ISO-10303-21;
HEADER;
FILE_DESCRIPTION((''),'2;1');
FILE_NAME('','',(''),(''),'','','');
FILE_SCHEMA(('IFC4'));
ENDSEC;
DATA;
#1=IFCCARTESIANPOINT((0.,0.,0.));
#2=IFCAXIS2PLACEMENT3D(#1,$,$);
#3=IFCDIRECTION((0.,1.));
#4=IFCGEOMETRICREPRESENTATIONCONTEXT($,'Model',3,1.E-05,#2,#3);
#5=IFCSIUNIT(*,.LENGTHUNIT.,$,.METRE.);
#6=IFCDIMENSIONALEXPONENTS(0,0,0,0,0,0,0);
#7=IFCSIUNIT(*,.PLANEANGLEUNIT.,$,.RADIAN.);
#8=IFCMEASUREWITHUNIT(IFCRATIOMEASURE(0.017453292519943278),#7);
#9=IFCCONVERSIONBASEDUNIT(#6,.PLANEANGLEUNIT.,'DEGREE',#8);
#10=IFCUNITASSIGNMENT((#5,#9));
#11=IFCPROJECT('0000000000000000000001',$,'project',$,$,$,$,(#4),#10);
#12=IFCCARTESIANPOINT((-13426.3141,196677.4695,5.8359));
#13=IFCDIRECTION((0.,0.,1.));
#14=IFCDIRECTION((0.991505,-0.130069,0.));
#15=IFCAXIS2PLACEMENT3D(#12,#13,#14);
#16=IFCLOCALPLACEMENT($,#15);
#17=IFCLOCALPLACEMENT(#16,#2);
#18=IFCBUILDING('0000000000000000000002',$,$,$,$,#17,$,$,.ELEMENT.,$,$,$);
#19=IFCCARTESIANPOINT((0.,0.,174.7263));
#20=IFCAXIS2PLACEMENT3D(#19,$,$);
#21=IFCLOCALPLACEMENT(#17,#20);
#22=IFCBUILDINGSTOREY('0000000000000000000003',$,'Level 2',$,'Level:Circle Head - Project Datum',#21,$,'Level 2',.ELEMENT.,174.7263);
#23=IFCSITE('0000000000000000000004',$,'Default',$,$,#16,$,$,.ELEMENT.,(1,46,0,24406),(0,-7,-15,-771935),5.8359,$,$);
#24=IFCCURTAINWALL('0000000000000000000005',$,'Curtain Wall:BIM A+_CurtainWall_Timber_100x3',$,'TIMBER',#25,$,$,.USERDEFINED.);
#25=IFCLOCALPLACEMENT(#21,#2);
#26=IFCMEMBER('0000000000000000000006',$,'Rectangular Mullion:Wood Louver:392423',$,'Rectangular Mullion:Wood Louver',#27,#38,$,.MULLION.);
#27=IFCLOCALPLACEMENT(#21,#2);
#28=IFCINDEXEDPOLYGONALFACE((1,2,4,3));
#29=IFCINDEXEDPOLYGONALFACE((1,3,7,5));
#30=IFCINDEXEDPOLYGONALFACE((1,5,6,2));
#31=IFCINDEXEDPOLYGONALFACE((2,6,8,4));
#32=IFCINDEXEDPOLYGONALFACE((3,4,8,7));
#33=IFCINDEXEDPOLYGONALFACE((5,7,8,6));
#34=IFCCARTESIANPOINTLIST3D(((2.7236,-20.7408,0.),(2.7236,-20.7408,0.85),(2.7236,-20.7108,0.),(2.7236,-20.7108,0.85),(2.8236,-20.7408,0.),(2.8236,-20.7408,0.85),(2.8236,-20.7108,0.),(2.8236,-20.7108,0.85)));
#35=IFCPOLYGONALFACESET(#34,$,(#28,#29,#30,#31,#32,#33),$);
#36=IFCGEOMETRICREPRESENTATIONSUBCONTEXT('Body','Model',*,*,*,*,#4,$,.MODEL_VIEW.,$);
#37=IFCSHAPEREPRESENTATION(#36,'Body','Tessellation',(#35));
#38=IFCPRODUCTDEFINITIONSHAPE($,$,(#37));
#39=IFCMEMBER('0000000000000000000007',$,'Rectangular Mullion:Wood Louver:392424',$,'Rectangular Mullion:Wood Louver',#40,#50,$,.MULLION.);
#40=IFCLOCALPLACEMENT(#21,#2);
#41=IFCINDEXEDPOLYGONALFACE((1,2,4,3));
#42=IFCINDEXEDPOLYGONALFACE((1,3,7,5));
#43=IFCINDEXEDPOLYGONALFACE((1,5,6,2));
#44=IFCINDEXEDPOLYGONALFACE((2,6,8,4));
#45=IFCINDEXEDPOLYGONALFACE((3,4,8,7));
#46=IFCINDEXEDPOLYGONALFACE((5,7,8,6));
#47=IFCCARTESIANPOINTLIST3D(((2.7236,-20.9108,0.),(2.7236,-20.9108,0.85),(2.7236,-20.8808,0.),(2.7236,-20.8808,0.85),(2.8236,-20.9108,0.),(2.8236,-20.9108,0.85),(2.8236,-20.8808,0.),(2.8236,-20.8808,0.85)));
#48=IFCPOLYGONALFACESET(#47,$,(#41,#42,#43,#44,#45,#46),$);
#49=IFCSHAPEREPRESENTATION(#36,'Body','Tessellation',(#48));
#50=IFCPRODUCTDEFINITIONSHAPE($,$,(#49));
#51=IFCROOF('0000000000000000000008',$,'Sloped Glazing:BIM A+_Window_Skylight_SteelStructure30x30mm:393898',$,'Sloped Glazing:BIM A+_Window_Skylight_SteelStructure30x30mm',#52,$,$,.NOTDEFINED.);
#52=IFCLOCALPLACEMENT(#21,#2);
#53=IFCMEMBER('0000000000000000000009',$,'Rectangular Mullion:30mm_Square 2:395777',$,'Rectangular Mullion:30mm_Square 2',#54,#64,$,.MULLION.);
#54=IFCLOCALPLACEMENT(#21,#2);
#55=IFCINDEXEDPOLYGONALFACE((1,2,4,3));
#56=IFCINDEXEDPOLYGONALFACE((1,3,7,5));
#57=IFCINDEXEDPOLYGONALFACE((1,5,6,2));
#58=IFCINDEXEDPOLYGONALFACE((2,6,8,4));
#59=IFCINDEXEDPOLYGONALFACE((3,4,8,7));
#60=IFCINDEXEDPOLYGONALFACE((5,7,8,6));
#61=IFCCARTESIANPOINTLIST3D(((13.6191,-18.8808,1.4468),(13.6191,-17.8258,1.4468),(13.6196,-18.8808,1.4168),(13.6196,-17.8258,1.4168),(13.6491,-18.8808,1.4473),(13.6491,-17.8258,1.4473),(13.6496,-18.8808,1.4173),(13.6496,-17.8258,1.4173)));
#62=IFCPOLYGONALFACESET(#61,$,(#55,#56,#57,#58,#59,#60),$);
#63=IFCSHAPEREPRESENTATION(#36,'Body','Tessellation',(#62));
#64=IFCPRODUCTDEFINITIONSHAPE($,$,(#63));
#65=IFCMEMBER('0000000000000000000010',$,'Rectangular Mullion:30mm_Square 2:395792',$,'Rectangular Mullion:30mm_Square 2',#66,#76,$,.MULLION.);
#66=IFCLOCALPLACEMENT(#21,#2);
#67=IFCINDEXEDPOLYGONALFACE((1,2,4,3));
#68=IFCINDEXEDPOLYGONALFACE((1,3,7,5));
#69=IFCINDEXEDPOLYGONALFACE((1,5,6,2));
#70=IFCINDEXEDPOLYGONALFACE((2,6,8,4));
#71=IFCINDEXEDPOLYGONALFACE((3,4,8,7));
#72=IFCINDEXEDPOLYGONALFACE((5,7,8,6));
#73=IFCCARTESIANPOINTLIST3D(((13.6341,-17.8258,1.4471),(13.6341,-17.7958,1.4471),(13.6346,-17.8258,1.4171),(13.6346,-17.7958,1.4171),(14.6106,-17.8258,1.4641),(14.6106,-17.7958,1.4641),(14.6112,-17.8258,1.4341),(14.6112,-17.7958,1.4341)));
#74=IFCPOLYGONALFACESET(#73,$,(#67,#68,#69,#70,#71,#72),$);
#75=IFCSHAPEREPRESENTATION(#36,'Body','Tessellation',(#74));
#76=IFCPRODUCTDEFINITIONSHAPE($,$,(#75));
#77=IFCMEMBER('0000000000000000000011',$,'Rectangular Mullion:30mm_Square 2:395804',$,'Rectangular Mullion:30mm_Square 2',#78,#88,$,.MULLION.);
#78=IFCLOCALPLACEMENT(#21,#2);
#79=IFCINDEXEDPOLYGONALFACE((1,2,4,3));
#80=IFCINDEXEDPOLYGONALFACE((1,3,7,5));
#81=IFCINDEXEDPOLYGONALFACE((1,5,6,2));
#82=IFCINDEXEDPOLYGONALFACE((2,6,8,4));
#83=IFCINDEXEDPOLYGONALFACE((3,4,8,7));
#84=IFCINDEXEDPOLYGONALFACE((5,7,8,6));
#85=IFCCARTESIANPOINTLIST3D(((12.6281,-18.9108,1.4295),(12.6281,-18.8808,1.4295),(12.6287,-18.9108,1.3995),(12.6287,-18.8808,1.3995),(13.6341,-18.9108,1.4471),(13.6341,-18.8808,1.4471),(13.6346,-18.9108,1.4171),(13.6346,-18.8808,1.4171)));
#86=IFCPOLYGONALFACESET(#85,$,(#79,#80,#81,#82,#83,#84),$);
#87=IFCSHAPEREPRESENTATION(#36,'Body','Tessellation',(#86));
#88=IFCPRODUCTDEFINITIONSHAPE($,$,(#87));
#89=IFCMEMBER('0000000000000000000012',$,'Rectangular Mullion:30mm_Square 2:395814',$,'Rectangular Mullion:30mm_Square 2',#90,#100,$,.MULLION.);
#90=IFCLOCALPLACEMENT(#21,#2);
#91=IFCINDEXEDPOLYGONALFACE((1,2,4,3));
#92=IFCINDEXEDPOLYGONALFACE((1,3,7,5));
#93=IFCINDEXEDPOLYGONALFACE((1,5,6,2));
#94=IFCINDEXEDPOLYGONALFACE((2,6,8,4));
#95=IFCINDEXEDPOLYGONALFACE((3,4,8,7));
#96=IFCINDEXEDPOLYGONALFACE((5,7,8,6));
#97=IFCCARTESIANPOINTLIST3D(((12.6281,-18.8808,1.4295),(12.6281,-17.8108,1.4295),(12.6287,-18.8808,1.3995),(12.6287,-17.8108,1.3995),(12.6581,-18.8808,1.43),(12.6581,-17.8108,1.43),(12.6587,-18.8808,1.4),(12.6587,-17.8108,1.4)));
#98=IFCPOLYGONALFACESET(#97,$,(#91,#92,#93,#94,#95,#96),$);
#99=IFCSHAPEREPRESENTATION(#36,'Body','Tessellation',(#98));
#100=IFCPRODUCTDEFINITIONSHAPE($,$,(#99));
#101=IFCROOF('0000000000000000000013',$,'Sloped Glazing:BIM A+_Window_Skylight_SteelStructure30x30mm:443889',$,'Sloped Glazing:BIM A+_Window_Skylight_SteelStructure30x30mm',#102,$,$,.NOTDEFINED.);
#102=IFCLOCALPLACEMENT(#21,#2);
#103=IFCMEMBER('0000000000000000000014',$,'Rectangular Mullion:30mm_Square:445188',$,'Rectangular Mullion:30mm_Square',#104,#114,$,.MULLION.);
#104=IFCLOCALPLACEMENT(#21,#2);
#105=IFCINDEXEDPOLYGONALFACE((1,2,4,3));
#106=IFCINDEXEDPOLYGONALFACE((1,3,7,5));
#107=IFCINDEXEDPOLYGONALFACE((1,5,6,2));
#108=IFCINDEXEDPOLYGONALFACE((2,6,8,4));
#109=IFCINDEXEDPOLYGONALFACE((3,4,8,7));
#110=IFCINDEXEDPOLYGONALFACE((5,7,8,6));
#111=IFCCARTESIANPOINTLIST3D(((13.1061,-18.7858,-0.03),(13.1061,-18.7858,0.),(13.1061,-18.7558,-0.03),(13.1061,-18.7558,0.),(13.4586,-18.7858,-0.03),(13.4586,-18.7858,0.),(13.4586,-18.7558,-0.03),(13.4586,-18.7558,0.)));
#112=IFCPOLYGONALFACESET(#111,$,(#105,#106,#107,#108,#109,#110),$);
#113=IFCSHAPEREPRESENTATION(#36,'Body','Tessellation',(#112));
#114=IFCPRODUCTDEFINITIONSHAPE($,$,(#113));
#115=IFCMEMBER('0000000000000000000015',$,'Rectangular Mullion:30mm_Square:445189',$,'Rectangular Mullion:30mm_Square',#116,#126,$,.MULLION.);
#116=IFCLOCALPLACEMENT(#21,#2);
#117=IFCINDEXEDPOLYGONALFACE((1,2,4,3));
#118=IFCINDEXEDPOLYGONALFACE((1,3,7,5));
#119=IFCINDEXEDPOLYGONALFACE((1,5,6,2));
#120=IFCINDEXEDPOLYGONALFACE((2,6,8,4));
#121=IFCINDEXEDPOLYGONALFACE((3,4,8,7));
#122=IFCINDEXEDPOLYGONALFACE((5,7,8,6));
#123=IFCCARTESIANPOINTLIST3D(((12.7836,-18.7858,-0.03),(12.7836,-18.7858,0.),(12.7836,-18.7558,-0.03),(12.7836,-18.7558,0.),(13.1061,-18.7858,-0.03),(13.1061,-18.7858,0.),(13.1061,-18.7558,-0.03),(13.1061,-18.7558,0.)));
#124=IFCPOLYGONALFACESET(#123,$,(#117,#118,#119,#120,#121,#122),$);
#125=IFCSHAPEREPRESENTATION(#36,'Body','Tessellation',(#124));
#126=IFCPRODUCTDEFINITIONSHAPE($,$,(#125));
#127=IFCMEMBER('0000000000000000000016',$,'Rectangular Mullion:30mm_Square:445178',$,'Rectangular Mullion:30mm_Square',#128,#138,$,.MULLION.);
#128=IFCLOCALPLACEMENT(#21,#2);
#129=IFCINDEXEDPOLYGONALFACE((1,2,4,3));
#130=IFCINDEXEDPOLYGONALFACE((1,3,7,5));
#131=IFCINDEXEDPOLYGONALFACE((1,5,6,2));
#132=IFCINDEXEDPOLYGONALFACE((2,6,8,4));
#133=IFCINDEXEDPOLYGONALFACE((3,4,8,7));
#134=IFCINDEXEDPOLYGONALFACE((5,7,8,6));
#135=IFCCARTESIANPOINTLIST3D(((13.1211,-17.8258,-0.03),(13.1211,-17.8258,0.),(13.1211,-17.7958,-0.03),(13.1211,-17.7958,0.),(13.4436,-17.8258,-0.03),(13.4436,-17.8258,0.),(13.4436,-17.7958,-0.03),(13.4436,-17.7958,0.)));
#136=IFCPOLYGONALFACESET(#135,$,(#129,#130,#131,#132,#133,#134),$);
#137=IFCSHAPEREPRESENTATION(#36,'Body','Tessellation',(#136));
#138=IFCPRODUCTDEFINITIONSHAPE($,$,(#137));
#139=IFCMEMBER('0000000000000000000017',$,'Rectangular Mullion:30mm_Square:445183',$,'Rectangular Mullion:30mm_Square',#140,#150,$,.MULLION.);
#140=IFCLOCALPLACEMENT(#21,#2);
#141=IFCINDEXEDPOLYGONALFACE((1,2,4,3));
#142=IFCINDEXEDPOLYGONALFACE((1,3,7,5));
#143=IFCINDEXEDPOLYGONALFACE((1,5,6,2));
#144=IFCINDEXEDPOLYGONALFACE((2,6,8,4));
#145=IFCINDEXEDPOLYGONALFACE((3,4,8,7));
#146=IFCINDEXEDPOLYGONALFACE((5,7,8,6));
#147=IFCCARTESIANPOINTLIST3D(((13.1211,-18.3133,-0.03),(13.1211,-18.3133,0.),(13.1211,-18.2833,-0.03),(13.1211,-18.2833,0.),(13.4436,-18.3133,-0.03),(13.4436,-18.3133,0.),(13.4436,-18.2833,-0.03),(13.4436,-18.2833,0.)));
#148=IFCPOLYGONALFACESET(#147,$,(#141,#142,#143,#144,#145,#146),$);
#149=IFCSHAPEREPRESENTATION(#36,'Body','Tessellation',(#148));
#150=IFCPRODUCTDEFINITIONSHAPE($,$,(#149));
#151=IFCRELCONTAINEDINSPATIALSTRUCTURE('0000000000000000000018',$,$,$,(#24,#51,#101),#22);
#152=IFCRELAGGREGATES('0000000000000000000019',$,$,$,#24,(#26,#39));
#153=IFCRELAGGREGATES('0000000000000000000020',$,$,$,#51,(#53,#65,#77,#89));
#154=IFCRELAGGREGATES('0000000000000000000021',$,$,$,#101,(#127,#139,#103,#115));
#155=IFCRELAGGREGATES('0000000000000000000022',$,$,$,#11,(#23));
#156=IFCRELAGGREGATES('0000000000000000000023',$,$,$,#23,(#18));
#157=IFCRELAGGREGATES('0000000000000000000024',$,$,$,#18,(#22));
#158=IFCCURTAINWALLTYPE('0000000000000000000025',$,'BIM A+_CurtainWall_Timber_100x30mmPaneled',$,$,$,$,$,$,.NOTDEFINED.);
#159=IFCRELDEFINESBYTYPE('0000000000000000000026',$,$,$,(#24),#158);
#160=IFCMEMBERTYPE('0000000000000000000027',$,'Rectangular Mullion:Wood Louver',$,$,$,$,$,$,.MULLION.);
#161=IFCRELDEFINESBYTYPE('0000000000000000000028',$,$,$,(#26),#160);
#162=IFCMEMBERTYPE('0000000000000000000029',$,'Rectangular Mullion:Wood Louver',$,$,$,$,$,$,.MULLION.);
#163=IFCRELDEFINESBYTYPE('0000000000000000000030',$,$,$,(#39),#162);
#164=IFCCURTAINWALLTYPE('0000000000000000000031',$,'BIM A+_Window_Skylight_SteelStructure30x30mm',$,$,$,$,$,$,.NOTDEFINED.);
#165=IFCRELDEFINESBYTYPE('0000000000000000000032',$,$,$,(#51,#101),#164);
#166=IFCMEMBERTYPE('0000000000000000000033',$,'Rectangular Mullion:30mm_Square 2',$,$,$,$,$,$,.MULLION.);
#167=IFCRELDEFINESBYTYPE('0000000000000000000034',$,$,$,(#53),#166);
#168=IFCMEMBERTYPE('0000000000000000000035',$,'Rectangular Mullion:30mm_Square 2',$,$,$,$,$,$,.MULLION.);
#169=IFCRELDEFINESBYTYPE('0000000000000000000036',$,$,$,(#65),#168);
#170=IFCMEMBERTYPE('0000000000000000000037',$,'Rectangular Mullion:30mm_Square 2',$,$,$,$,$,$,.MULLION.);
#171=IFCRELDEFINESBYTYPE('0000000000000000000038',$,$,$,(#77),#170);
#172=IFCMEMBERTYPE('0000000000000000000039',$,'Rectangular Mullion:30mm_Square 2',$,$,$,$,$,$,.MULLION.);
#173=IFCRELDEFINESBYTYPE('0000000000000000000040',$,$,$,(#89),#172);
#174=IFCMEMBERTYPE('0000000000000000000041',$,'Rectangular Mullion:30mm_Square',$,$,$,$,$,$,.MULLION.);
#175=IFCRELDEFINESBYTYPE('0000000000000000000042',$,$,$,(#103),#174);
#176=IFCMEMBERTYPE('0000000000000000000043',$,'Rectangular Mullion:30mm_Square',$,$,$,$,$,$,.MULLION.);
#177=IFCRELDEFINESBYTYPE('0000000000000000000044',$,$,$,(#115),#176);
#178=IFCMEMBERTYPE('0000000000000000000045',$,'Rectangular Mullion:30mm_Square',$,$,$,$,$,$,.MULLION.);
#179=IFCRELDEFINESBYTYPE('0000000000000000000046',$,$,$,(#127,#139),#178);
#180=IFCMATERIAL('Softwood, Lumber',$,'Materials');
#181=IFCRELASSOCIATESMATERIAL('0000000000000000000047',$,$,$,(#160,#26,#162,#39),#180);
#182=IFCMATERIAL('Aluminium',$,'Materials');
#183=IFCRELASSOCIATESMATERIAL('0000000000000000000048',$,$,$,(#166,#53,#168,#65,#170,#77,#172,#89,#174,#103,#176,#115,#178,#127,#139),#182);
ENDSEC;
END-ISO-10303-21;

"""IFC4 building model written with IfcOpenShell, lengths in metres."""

from ifc_helpers import new_model, entity, si_unit, converted_unit, direction, frame, origin, place, context, subcontext, project, spatial, indexed_curve, outline, extrude, source, transform, mapped, material, type_object, type_shapes, element, aggregate, save


model = new_model("IFC4")

# Units and contexts
model_context = context("Model", 3, precision=1e-05, world=origin(), true_north=direction((0.0, 1.0)))
body_context = subcontext(model_context, "Body", "Model", "MODEL_VIEW")
ifc_project = project(units=[si_unit("LENGTHUNIT", "METRE"), converted_unit("PLANEANGLEUNIT", "DEGREE", entity("IfcRatioMeasure", 0.017453292519943278), si_unit("PLANEANGLEUNIT", "RADIAN"), dimensions=[0, 0, 0, 0, 0, 0, 0])], contexts=[model_context])

# Site, building, storey
site_placement = place(None, frame((-13426.3141, 196677.4695, 5.8359), z_axis=(0.0, 0.0, 1.0), x_axis=(0.991505, -0.130069, 0.0)))
site = spatial("IfcSite", under=ifc_project, at=site_placement, Name="Default", CompositionType="ELEMENT", RefLatitude=(1, 46, 0, 24406), RefLongitude=(0, -7, -15, -771935), RefElevation=5.8359)
building_placement = place(site_placement, origin())
building = spatial("IfcBuilding", under=site, at=building_placement, CompositionType="ELEMENT")
storey_placement = place(building_placement, frame((0.0, 0.0, 174.7263)))
storey = spatial("IfcBuildingStorey", under=building, at=storey_placement, Name="Level 2", ObjectType="Level:Circle Head - Project Datum", LongName="Level 2", CompositionType="ELEMENT", Elevation=174.7263)

# Curtain wall, members
curtain_wall_type_1 = type_object("IfcCurtainWallType", Name="BIM A+_CurtainWall_Timber_100x30mmPaneled", PredefinedType="NOTDEFINED")
curtain_wall_placement = place(storey_placement, frame((0.0, 0.0, -174.7263)))
curtain_wall = element("IfcCurtainWall", 1, at=curtain_wall_placement, inside=storey, type_object=curtain_wall_type_1, Name="Curtain Wall:BIM A+_CurtainWall_Timber_100x3", ObjectType="TIMBER", PredefinedType="USERDEFINED")
ifc_material_1 = material(Name="Softwood, Lumber", Category="Materials")
member_type_1 = type_object("IfcMemberType", Name="Rectangular Mullion:Wood Louver", PredefinedType="MULLION", material=ifc_material_1)
shared_shape_1 = source(origin(), body_context, "Body", "SweptSolid", [
    extrude(outline(indexed_curve([(-0.05, -0.015), (0.05, -0.015), (0.05, 0.015), (-0.05, 0.015), (-0.05, -0.015)], self_intersect=False)), frame((-0.015, -0.035, -0.85), z_axis=(0.0, 0.0, 1.0), x_axis=(0.0, -1.0, 0.0)), (0.0, 0.0, 1.0), 0.85),
])
type_shapes(member_type_1, [shared_shape_1])
member_1_placement = place(curtain_wall_placement, frame((2.8086, -20.7108, 174.7263), z_axis=(0.0, 0.0, -1.0), x_axis=(0.0, 1.0, 0.0)))
member_1 = element("IfcMember", 2, at=member_1_placement, type_object=member_type_1, material=ifc_material_1, Name="Rectangular Mullion:Wood Louver:392423", ObjectType="Rectangular Mullion:Wood Louver", PredefinedType="MULLION", context=body_context, shape_type="MappedRepresentation", body=[
    mapped(shared_shape_1, transform((0.0, 0.0, 0.0), scale=1.0)),
])
member_type_2 = type_object("IfcMemberType", Name="Rectangular Mullion:Wood Louver", PredefinedType="MULLION", material=ifc_material_1)
shared_shape_2 = source(origin(), body_context, "Body", "SweptSolid", [
    extrude(outline(indexed_curve([(-0.05, -0.015), (0.05, -0.015), (0.05, 0.015), (-0.05, 0.015), (-0.05, -0.015)], self_intersect=False)), frame((-0.015, -0.035, -0.85), z_axis=(0.0, 0.0, 1.0), x_axis=(0.0, -1.0, 0.0)), (0.0, 0.0, 1.0), 0.85),
])
type_shapes(member_type_2, [shared_shape_2])
member_2_placement = place(curtain_wall_placement, frame((2.8086, -20.9108, 175.5763), z_axis=(0.0, 0.0, 1.0), x_axis=(0.0, -1.0, 0.0)))
member_2 = element("IfcMember", 3, at=member_2_placement, type_object=member_type_2, material=ifc_material_1, Name="Rectangular Mullion:Wood Louver:392424", ObjectType="Rectangular Mullion:Wood Louver", PredefinedType="MULLION", context=body_context, shape_type="MappedRepresentation", body=[
    mapped(shared_shape_2, transform((0.0, 0.0, 0.0), scale=1.0)),
])

# Roofs, members
curtain_wall_type_2 = type_object("IfcCurtainWallType", Name="BIM A+_Window_Skylight_SteelStructure30x30mm", PredefinedType="NOTDEFINED")
roof_1_placement = place(storey_placement, frame((0.0, 0.0, -174.7263)))
roof_1 = element("IfcRoof", 4, at=roof_1_placement, inside=storey, type_object=curtain_wall_type_2, Name="Sloped Glazing:BIM A+_Window_Skylight_SteelStructure30x30mm:393898", ObjectType="Sloped Glazing:BIM A+_Window_Skylight_SteelStructure30x30mm", PredefinedType="NOTDEFINED")
ifc_material_2 = material(Name="Aluminium", Category="Materials")
member_type_3 = type_object("IfcMemberType", Name="Rectangular Mullion:30mm_Square 2", PredefinedType="MULLION", material=ifc_material_2)
shared_shape_3 = source(origin(), body_context, "Body", "SweptSolid", [
    extrude(outline(indexed_curve([(-0.015, -0.015), (0.015, -0.015), (0.015, 0.015), (-0.015, 0.015), (-0.015, -0.015)], self_intersect=False)), frame((0.0, -0.0095, -1.055), z_axis=(0.0, 0.0, 1.0), x_axis=(0.0, -1.0, 0.0)), (0.0, 0.0, 1.0), 1.055),
])
type_shapes(member_type_3, [shared_shape_3])
member_3_placement = place(roof_1_placement, frame((13.6345, -17.8258, 176.1489), z_axis=(0.0, 1.0, 0.0), x_axis=(0.999848, 0.0, 0.017452)))
member_3 = element("IfcMember", 5, at=member_3_placement, type_object=member_type_3, material=ifc_material_2, Name="Rectangular Mullion:30mm_Square 2:395777", ObjectType="Rectangular Mullion:30mm_Square 2", PredefinedType="MULLION", context=body_context, shape_type="MappedRepresentation", body=[
    mapped(shared_shape_3, transform((0.0, 0.0, 0.0), scale=1.0)),
])
member_type_4 = type_object("IfcMemberType", Name="Rectangular Mullion:30mm_Square 2", PredefinedType="MULLION", material=ifc_material_2)
shared_shape_4 = source(origin(), body_context, "Body", "SweptSolid", [
    extrude(outline(indexed_curve([(-0.015, -0.015), (0.015, -0.015), (0.015, 0.015), (-0.015, 0.015), (-0.015, -0.015)], self_intersect=False)), frame((0.0, -0.0095, -0.9767), z_axis=(0.0, 0.0, 1.0), x_axis=(0.0, -1.0, 0.0)), (0.0, 0.0, 1.0), 0.9767),
])
type_shapes(member_type_4, [shared_shape_4])
member_4_placement = place(roof_1_placement, frame((13.6345, -17.8108, 176.1489), z_axis=(-0.999848, 0.0, -0.017452), x_axis=(0.0, 1.0, 0.0)))
member_4 = element("IfcMember", 6, at=member_4_placement, type_object=member_type_4, material=ifc_material_2, Name="Rectangular Mullion:30mm_Square 2:395792", ObjectType="Rectangular Mullion:30mm_Square 2", PredefinedType="MULLION", context=body_context, shape_type="MappedRepresentation", body=[
    mapped(shared_shape_4, transform((0.0, 0.0, 0.0), scale=1.0)),
])
member_type_5 = type_object("IfcMemberType", Name="Rectangular Mullion:30mm_Square 2", PredefinedType="MULLION", material=ifc_material_2)
shared_shape_5 = source(origin(), body_context, "Body", "SweptSolid", [
    extrude(outline(indexed_curve([(-0.015, -0.015), (0.015, -0.015), (0.015, 0.015), (-0.015, 0.015), (-0.015, -0.015)], self_intersect=False)), frame((-0.015, -0.0095, -1.0061), z_axis=(0.0, 0.0, 1.0), x_axis=(0.0, -1.0, 0.0)), (0.0, 0.0, 1.0), 1.0061),
])
type_shapes(member_type_5, [shared_shape_5])
member_5_placement = place(roof_1_placement, frame((13.6345, -18.9108, 176.1489), z_axis=(0.999848, 0.0, 0.017452), x_axis=(0.0, -1.0, 0.0)))
member_5 = element("IfcMember", 7, at=member_5_placement, type_object=member_type_5, material=ifc_material_2, Name="Rectangular Mullion:30mm_Square 2:395804", ObjectType="Rectangular Mullion:30mm_Square 2", PredefinedType="MULLION", context=body_context, shape_type="MappedRepresentation", body=[
    mapped(shared_shape_5, transform((0.0, 0.0, 0.0), scale=1.0)),
])
member_type_6 = type_object("IfcMemberType", Name="Rectangular Mullion:30mm_Square 2", PredefinedType="MULLION", material=ifc_material_2)
shared_shape_6 = source(origin(), body_context, "Body", "SweptSolid", [
    extrude(outline(indexed_curve([(-0.015, -0.015), (0.015, -0.015), (0.015, 0.015), (-0.015, 0.015), (-0.015, -0.015)], self_intersect=False)), frame((-0.015, -0.0095, -1.07), z_axis=(0.0, 0.0, 1.0), x_axis=(0.0, -1.0, 0.0)), (0.0, 0.0, 1.0), 1.07),
])
type_shapes(member_type_6, [shared_shape_6])
member_6_placement = place(roof_1_placement, frame((12.6286, -18.8808, 176.1313), z_axis=(0.0, -1.0, 0.0), x_axis=(-0.999848, 0.0, -0.017452)))
member_6 = element("IfcMember", 8, at=member_6_placement, type_object=member_type_6, material=ifc_material_2, Name="Rectangular Mullion:30mm_Square 2:395814", ObjectType="Rectangular Mullion:30mm_Square 2", PredefinedType="MULLION", context=body_context, shape_type="MappedRepresentation", body=[
    mapped(shared_shape_6, transform((0.0, 0.0, 0.0), scale=1.0)),
])
roof_2_placement = place(storey_placement, frame((0.0, 0.0, -174.7263)))
roof_2 = element("IfcRoof", 9, at=roof_2_placement, inside=storey, type_object=curtain_wall_type_2, Name="Sloped Glazing:BIM A+_Window_Skylight_SteelStructure30x30mm:443889", ObjectType="Sloped Glazing:BIM A+_Window_Skylight_SteelStructure30x30mm", PredefinedType="NOTDEFINED")
member_type_7 = type_object("IfcMemberType", Name="Rectangular Mullion:30mm_Square", PredefinedType="MULLION", material=ifc_material_2)
shared_shape_7 = source(origin(), body_context, "Body", "SweptSolid", [
    extrude(outline(indexed_curve([(-0.015, -0.015), (0.015, -0.015), (0.015, 0.015), (-0.015, 0.015), (-0.015, -0.015)], self_intersect=False)), frame((-0.015, 0.0, -0.3525), z_axis=(0.0, 0.0, 1.0), x_axis=(0.0, -1.0, 0.0)), (0.0, 0.0, 1.0), 0.3525),
])
type_shapes(member_type_7, [shared_shape_7])
member_7_placement = place(roof_2_placement, frame((13.4586, -18.7858, 174.7113), z_axis=(1.0, 0.0, 0.0), x_axis=(0.0, -1.0, 0.0)))
member_7 = element("IfcMember", 10, at=member_7_placement, type_object=member_type_7, material=ifc_material_2, Name="Rectangular Mullion:30mm_Square:445188", ObjectType="Rectangular Mullion:30mm_Square", PredefinedType="MULLION", context=body_context, shape_type="MappedRepresentation", body=[
    mapped(shared_shape_7, transform((0.0, 0.0, 0.0), scale=1.0)),
])
member_type_8 = type_object("IfcMemberType", Name="Rectangular Mullion:30mm_Square", PredefinedType="MULLION", material=ifc_material_2)
shared_shape_8 = source(origin(), body_context, "Body", "SweptSolid", [
    extrude(outline(indexed_curve([(-0.015, -0.015), (0.015, -0.015), (0.015, 0.015), (-0.015, 0.015), (-0.015, -0.015)], self_intersect=False)), frame((-0.015, 0.0, -0.3225), z_axis=(0.0, 0.0, 1.0), x_axis=(0.0, -1.0, 0.0)), (0.0, 0.0, 1.0), 0.3225),
])
type_shapes(member_type_8, [shared_shape_8])
member_8_placement = place(roof_2_placement, frame((13.1061, -18.7858, 174.7113), z_axis=(1.0, 0.0, 0.0), x_axis=(0.0, -1.0, 0.0)))
member_8 = element("IfcMember", 11, at=member_8_placement, type_object=member_type_8, material=ifc_material_2, Name="Rectangular Mullion:30mm_Square:445189", ObjectType="Rectangular Mullion:30mm_Square", PredefinedType="MULLION", context=body_context, shape_type="MappedRepresentation", body=[
    mapped(shared_shape_8, transform((0.0, 0.0, 0.0), scale=1.0)),
])
member_type_9 = type_object("IfcMemberType", Name="Rectangular Mullion:30mm_Square", PredefinedType="MULLION", material=ifc_material_2)
shared_shape_9 = source(origin(), body_context, "Body", "SweptSolid", [
    extrude(outline(indexed_curve([(-0.015, -0.015), (0.015, -0.015), (0.015, 0.015), (-0.015, 0.015), (-0.015, -0.015)], self_intersect=False)), frame((0.0, 0.0, -0.3225), z_axis=(0.0, 0.0, 1.0), x_axis=(0.0, -1.0, 0.0)), (0.0, 0.0, 1.0), 0.3225),
])
type_shapes(member_type_9, [shared_shape_9])
member_9_placement = place(roof_2_placement, frame((13.4436, -17.8108, 174.7113), z_axis=(1.0, 0.0, 0.0), x_axis=(0.0, -1.0, 0.0)))
member_9 = element("IfcMember", 12, at=member_9_placement, type_object=member_type_9, material=ifc_material_2, Name="Rectangular Mullion:30mm_Square:445178", ObjectType="Rectangular Mullion:30mm_Square", PredefinedType="MULLION", context=body_context, shape_type="MappedRepresentation", body=[
    mapped(shared_shape_9, transform((0.0, 0.0, 0.0), scale=1.0)),
])
member_10_placement = place(roof_2_placement, frame((13.4436, -18.2983, 174.7113), z_axis=(1.0, 0.0, 0.0), x_axis=(0.0, -1.0, 0.0)))
member_10 = element("IfcMember", 13, at=member_10_placement, type_object=member_type_9, material=ifc_material_2, Name="Rectangular Mullion:30mm_Square:445183", ObjectType="Rectangular Mullion:30mm_Square", PredefinedType="MULLION", context=body_context, shape_type="MappedRepresentation", body=[
    mapped(shared_shape_9, transform((0.0, 0.0, 0.0), scale=1.0)),
])

aggregate(curtain_wall, [member_1, member_2])
aggregate(roof_1, [member_3, member_4, member_5, member_6])
aggregate(roof_2, [member_9, member_10, member_7, member_8])

save(model, "model.ifc")
